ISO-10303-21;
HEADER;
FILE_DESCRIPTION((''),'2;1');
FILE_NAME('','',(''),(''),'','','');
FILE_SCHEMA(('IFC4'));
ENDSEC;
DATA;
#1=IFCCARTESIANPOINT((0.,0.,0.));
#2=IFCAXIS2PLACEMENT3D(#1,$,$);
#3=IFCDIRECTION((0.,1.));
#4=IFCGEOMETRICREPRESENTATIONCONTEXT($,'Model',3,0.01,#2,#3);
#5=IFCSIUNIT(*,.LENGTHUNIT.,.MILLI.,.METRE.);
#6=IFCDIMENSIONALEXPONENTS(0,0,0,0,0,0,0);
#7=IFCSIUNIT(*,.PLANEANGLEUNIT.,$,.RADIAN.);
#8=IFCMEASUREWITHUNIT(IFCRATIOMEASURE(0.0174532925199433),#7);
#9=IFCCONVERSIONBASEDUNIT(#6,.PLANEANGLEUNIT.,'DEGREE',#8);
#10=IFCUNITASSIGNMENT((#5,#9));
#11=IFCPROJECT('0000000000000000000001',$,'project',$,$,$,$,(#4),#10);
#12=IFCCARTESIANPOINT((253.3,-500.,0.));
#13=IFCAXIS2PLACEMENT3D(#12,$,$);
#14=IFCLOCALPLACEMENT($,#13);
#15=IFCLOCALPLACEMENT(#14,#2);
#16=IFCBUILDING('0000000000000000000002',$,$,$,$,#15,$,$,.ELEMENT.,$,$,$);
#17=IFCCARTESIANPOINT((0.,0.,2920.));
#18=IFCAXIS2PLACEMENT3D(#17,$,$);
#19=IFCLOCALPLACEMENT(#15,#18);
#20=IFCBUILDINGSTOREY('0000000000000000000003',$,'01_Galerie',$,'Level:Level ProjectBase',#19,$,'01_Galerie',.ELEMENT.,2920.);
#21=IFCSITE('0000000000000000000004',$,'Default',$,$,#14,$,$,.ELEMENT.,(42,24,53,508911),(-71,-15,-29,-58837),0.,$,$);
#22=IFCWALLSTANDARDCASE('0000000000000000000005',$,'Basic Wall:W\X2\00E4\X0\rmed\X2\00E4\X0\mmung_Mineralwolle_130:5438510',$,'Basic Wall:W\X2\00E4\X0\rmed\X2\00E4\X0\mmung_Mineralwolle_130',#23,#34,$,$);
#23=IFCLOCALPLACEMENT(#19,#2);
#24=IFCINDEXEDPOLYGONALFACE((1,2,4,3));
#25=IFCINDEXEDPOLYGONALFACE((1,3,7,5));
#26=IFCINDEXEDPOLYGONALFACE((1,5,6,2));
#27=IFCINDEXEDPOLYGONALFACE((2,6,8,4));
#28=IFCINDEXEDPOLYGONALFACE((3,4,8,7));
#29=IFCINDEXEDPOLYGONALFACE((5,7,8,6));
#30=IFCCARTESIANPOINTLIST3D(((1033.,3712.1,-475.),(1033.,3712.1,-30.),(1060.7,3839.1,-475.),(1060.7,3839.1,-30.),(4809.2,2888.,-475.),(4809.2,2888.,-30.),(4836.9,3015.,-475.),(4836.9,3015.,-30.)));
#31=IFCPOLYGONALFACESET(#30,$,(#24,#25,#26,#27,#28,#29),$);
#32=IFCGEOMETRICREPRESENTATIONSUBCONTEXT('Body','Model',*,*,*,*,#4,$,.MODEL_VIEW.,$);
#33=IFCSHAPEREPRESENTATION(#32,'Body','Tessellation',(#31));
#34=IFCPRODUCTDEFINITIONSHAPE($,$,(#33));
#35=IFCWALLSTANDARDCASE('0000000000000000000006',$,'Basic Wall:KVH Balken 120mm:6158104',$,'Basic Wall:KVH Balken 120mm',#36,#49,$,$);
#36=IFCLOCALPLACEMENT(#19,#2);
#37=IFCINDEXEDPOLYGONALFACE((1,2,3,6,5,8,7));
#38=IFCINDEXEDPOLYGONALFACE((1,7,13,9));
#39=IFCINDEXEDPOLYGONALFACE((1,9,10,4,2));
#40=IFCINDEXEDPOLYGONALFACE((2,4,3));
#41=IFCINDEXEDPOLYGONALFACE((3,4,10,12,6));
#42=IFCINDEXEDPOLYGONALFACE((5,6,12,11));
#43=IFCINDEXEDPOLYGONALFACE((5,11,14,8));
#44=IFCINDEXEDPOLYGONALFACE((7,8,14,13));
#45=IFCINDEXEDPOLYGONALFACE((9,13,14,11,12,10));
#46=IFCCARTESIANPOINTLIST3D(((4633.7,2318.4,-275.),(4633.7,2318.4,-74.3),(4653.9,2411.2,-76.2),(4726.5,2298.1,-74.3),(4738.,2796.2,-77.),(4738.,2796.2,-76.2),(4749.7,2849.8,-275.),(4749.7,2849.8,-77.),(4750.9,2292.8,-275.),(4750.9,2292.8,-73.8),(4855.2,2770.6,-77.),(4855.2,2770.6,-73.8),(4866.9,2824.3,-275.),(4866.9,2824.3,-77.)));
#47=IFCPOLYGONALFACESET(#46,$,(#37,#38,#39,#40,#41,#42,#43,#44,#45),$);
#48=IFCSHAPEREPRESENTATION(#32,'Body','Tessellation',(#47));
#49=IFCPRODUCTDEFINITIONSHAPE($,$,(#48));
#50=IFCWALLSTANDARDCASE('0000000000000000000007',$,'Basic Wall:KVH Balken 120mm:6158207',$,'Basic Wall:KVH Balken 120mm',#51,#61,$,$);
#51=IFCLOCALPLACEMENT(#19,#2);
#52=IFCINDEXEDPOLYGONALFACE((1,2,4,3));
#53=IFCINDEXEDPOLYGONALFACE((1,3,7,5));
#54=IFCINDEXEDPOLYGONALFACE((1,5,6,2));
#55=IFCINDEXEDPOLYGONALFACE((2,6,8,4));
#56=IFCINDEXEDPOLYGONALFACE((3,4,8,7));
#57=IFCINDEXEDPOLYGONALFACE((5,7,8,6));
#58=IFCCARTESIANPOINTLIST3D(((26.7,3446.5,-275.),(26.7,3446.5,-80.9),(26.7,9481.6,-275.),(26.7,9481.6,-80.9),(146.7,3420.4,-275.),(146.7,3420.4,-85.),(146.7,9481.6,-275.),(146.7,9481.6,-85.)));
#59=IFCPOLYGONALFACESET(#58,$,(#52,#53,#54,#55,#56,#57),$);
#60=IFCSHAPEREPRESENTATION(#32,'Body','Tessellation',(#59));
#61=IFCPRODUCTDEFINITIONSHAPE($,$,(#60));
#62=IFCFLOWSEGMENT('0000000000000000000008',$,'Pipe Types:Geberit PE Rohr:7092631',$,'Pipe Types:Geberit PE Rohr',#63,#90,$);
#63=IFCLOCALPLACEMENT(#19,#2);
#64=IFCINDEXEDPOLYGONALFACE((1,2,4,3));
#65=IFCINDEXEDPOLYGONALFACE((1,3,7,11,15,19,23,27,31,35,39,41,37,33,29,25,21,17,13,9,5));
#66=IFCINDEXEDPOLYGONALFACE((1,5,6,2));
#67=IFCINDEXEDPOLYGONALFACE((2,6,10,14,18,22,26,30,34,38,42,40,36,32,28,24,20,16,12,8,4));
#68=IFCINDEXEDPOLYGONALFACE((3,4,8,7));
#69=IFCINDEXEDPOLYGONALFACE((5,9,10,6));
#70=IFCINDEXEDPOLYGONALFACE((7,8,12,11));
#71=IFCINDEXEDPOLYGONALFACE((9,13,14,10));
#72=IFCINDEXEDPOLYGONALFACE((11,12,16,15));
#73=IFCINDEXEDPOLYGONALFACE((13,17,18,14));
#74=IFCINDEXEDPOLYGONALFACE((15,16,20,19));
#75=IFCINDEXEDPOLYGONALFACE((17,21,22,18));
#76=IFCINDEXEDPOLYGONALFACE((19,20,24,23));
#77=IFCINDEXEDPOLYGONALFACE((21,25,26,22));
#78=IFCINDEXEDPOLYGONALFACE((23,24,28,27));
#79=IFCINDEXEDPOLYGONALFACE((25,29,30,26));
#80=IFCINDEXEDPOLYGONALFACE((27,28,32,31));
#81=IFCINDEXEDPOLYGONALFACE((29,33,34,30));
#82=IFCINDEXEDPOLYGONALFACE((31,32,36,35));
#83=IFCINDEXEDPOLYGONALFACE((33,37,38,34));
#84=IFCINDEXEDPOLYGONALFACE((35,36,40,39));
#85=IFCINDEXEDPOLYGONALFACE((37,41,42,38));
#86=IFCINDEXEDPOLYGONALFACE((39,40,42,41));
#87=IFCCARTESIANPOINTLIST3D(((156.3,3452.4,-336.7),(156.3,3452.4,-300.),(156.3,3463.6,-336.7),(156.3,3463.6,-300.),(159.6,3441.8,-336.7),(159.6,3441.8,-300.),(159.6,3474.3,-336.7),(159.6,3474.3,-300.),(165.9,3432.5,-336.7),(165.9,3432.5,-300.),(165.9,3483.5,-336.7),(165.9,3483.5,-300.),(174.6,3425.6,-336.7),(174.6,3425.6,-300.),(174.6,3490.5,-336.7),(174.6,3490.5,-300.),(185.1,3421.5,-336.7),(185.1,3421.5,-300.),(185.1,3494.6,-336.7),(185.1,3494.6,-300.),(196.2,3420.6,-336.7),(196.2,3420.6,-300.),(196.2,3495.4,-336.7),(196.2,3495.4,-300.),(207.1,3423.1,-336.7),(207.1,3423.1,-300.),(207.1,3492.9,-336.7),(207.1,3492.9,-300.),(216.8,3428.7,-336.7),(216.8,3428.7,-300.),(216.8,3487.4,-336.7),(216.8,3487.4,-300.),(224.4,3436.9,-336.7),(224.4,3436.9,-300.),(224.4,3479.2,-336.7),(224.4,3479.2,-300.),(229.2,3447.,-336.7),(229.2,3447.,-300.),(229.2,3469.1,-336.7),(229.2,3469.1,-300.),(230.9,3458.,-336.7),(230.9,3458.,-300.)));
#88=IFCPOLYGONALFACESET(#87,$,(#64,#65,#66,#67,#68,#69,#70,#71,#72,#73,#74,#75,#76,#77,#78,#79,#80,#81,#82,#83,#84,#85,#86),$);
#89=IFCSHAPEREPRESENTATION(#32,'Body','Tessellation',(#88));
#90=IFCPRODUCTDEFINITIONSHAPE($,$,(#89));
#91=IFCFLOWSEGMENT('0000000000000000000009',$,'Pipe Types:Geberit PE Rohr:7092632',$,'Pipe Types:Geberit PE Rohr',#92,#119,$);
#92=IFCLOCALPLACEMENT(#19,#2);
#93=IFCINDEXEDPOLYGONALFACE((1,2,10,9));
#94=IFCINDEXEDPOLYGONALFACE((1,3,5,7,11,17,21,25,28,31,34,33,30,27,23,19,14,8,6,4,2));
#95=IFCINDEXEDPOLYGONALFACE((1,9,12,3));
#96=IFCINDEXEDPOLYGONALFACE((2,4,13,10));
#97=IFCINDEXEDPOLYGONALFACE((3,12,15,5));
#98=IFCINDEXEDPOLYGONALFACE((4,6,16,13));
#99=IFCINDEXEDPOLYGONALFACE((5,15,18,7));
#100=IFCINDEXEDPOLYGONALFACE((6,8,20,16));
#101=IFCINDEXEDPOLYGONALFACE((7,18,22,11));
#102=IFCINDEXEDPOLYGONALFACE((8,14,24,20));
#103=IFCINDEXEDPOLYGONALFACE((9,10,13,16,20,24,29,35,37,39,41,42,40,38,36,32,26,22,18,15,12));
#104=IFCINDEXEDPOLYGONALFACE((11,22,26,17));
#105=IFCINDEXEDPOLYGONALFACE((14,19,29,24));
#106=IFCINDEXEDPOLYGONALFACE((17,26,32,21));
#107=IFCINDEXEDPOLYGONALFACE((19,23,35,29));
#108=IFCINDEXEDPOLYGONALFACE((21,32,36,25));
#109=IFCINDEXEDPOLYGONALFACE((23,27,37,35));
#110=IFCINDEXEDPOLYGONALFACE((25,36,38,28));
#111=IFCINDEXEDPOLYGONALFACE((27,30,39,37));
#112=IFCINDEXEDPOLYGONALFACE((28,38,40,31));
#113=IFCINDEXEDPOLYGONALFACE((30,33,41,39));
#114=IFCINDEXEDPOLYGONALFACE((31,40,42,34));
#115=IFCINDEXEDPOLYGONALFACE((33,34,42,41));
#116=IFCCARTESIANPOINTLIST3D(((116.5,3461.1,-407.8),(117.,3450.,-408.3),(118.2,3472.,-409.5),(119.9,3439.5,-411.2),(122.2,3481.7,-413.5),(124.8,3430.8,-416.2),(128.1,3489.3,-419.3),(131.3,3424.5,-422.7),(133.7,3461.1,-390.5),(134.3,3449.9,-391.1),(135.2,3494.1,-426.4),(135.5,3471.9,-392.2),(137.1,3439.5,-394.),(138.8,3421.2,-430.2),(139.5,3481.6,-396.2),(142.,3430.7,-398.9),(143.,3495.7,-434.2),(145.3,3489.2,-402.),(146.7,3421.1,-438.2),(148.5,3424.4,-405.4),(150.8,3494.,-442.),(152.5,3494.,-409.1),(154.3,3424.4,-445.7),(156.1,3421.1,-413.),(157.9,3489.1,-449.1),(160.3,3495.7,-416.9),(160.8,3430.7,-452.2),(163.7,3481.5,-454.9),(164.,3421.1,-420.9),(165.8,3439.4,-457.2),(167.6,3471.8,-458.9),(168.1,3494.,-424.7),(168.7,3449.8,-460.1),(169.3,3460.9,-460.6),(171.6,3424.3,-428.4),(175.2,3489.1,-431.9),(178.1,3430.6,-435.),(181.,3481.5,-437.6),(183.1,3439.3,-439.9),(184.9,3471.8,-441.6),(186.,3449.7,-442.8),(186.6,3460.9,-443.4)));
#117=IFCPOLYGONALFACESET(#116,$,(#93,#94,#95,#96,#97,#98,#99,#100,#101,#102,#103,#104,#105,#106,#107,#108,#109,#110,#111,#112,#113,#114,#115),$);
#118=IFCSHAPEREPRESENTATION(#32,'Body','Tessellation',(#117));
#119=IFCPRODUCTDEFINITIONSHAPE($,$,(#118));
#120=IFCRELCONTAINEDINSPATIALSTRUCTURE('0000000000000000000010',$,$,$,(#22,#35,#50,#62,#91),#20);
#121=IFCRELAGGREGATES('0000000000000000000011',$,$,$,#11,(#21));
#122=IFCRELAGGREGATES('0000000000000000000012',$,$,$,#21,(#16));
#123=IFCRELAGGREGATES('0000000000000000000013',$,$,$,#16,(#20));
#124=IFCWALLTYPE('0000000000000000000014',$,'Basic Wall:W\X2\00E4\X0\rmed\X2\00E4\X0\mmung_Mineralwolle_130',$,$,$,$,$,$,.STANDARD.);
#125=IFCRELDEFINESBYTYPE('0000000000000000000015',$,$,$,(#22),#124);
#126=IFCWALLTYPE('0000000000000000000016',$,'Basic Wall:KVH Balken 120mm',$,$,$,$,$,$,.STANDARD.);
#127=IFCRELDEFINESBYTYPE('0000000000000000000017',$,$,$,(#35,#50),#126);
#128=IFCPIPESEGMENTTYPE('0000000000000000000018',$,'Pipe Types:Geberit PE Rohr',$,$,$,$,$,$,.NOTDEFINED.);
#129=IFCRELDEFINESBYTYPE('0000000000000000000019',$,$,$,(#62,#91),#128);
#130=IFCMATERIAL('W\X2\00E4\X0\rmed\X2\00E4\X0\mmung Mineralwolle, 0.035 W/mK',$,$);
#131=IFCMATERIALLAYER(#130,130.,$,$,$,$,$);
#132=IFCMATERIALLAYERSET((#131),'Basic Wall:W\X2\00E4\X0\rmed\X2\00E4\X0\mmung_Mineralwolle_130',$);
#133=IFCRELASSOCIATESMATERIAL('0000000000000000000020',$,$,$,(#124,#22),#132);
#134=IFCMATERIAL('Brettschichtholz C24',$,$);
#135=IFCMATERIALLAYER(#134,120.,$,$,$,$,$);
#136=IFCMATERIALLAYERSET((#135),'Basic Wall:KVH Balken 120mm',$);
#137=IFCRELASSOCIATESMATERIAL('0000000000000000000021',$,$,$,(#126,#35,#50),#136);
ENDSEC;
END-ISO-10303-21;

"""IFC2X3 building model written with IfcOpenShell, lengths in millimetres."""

from ifc_helpers import new_model, entity, si_unit, converted_unit, direction, frame, frame_2d, origin, place, context, subcontext, project, spatial, polyline, rectangle, circle, outline, extrude, clip, bounded_halfspace, material, layer, layer_set, layer_usage, type_object, element, save


model = new_model("IFC2X3")

# Units and contexts
model_context = context("Model", 3, precision=0.01, world=origin(), true_north=direction((0.0, 1.0)))
body_context = subcontext(model_context, "Body", "Model", "MODEL_VIEW")
ifc_project = project(units=[si_unit("LENGTHUNIT", "METRE", prefix="MILLI"), converted_unit("PLANEANGLEUNIT", "DEGREE", entity("IfcRatioMeasure", 0.0174532925199433), si_unit("PLANEANGLEUNIT", "RADIAN"), dimensions=[0, 0, 0, 0, 0, 0, 0])], contexts=[model_context])

# Site, building, storey
site_placement = place(None, frame((253.3, -500.0, 0.0)))
site = spatial("IfcSite", under=ifc_project, at=site_placement, Name="Default", CompositionType="ELEMENT", RefLatitude=(42, 24, 53, 508911), RefLongitude=(-71, -15, -29, -58837), RefElevation=0.0)
building_placement = place(site_placement, origin())
building = spatial("IfcBuilding", under=site, at=building_placement, CompositionType="ELEMENT")
storey_placement = place(building_placement, frame((0.0, 0.0, 2920.0)))
storey = spatial("IfcBuildingStorey", under=building, at=storey_placement, Name="01_Galerie", ObjectType="Level:Level ProjectBase", LongName="01_Galerie", CompositionType="ELEMENT", Elevation=2920.0)

# Walls
ifc_material_1 = material(Name="Wärmedämmung Mineralwolle, 0.035 W/mK")
ifc_layer_1 = layer(ifc_material_1, 130.0)
ifc_layer_set_1 = layer_set([ifc_layer_1], Name="Basic Wall:Wärmedämmung_Mineralwolle_130")
ifc_layer_usage_1 = layer_usage(ifc_layer_set_1, "AXIS2", "NEGATIVE", 65.0)
wall_type_1 = type_object("IfcWallType", Name="Basic Wall:Wärmedämmung_Mineralwolle_130", PredefinedType="STANDARD", material=ifc_layer_set_1)
wall_1_placement = place(storey_placement, frame((1046.9, 3775.6, -475.0), z_axis=(0.0, 0.0, 1.0), x_axis=(0.977008, -0.213201, 0.0)))
element("IfcWallStandardCase", 1, at=wall_1_placement, inside=storey, type_object=wall_type_1, material=ifc_layer_usage_1, Name="Basic Wall:Wärmedämmung_Mineralwolle_130:5438510", ObjectType="Basic Wall:Wärmedämmung_Mineralwolle_130", context=body_context, shape_type="SweptSolid", body=[
    extrude(rectangle(XDim=3865.0, YDim=130.0, at=frame_2d((1932.5, 0.0), x_axis=(-1.0, 0.0))), origin(), (0.0, 0.0, 1.0), 445.0),
])
ifc_material_2 = material(Name="Brettschichtholz C24")
ifc_layer_2 = layer(ifc_material_2, 120.0)
ifc_layer_set_2 = layer_set([ifc_layer_2], Name="Basic Wall:KVH Balken 120mm")
ifc_layer_usage_2 = layer_usage(ifc_layer_set_2, "AXIS2", "NEGATIVE", 60.0)
wall_type_2 = type_object("IfcWallType", Name="Basic Wall:KVH Balken 120mm", PredefinedType="STANDARD", material=ifc_layer_set_2)
wall_2_placement = place(storey_placement, frame((4808.3, 2837.0, -275.0), z_axis=(0.0, 0.0, 1.0), x_axis=(-0.213201, -0.977008, 0.0)))
element("IfcWallStandardCase", 2, at=wall_2_placement, inside=storey, type_object=wall_type_2, material=ifc_layer_usage_2, Name="Basic Wall:KVH Balken 120mm:6158104", ObjectType="Basic Wall:KVH Balken 120mm", context=body_context, shape_type="Clipping", body=[
    clip(clip(clip(extrude(rectangle(XDim=544.0, YDim=120.0, at=frame_2d((272.0, 0.0), x_axis=(-1.0, 0.0))), origin(), (0.0, 0.0, 1.0), 201.2), bounded_halfspace(frame((54.9, -60.0, 198.8), z_axis=(0.0, 0.02007, -0.999799), x_axis=(1.0, 0.0, 0.0)), True, frame((54.9, -60.0, 198.8)), polyline([(0.0, 0.0), (394.1, 0.0), (489.0, 95.0), (489.0, 120.0), (0.0, 120.0), (0.0, 0.0)]))), bounded_halfspace(frame((449.0, -60.0, 198.8), z_axis=(0.02007, 0.0, -0.999799), x_axis=(0.0, -1.0, 0.0)), True, frame((449.0, -60.0, 198.8)), polyline([(0.0, 0.0), (95.0, 0.0), (95.0, 95.0), (0.0, 0.0)]))), bounded_halfspace(frame((0.0, -60.0, 198.0), z_axis=(0.0, 0.0, 1.0), x_axis=(0.0, 1.0, 0.0)), False, frame((0.0, -60.0, 198.0)), polyline([(0.0, 0.0), (54.9, 0.0), (54.9, 120.0), (0.0, 120.0), (0.0, 0.0)]))),
])
ifc_layer_usage_3 = layer_usage(ifc_layer_set_2, "AXIS2", "NEGATIVE", 60.0)
wall_3_placement = place(storey_placement, frame((86.7, 3420.4, -275.0), z_axis=(0.0, 0.0, 1.0), x_axis=(0.0, 1.0, 0.0)))
element("IfcWallStandardCase", 3, at=wall_3_placement, inside=storey, type_object=wall_type_2, material=ifc_layer_usage_3, Name="Basic Wall:KVH Balken 120mm:6158207", ObjectType="Basic Wall:KVH Balken 120mm", context=body_context, shape_type="Clipping", body=[
    clip(extrude(outline(polyline([(6061.3, -60.0), (6061.3, 60.0), (662.5, 60.0), (476.3, 60.0), (26.2, 60.0), (0.0, -60.0), (5941.3, -60.0), (6061.3, -60.0)])), origin(), (0.0, 0.0, 1.0), 194.1), bounded_halfspace(frame((0.0, -60.0, 190.0), z_axis=(0.0, 0.034899, -0.999391), x_axis=(1.0, 0.0, 0.0)), True, frame((0.0, -60.0, 190.0)), polyline([(0.0, 0.0), (6061.3, 0.0), (6061.3, 120.0), (662.5, 120.0), (476.3, 120.0), (26.2, 120.0), (0.0, 0.0)]))),
])

# Flow segments
pipe_segment_type = type_object("IfcPipeSegmentType", Name="Pipe Types:Geberit PE Rohr", PredefinedType="NOTDEFINED")
flow_segment_1_placement = place(storey_placement, frame((154.3, 3418.9, -336.7)))
element("IfcFlowSegment", 4, at=flow_segment_1_placement, inside=storey, type_object=pipe_segment_type, Name="Pipe Types:Geberit PE Rohr:7092631", ObjectType="Pipe Types:Geberit PE Rohr", context=body_context, shape_type="SweptSolid", body=[
    extrude(circle(Radius=37.5, at=frame_2d((0.0, 0.0), x_axis=(1.0, 0.0))), frame((39.1, 39.1, 0.0), z_axis=(0.0, -0.000103, 1.0), x_axis=(1.0, 0.0, 0.0)), (0.0, 0.0, 1.0), 36.7),
])
flow_segment_2_placement = place(storey_placement, frame((114.8, 3419.1, -462.3)))
element("IfcFlowSegment", 5, at=flow_segment_2_placement, inside=storey, type_object=pipe_segment_type, Name="Pipe Types:Geberit PE Rohr:7092632", ObjectType="Pipe Types:Geberit PE Rohr", context=body_context, shape_type="SweptSolid", body=[
    extrude(circle(Radius=37.5, at=frame_2d((0.0, 0.0), x_axis=(1.0, 0.0))), frame((45.4, 39.1, 45.4), z_axis=(-0.707107, 0.00248, -0.707102), x_axis=(0.003507, 0.999994, 0.0)), (0.0, 0.0, 1.0), 24.4),
])

save(model, "model.ifc")
